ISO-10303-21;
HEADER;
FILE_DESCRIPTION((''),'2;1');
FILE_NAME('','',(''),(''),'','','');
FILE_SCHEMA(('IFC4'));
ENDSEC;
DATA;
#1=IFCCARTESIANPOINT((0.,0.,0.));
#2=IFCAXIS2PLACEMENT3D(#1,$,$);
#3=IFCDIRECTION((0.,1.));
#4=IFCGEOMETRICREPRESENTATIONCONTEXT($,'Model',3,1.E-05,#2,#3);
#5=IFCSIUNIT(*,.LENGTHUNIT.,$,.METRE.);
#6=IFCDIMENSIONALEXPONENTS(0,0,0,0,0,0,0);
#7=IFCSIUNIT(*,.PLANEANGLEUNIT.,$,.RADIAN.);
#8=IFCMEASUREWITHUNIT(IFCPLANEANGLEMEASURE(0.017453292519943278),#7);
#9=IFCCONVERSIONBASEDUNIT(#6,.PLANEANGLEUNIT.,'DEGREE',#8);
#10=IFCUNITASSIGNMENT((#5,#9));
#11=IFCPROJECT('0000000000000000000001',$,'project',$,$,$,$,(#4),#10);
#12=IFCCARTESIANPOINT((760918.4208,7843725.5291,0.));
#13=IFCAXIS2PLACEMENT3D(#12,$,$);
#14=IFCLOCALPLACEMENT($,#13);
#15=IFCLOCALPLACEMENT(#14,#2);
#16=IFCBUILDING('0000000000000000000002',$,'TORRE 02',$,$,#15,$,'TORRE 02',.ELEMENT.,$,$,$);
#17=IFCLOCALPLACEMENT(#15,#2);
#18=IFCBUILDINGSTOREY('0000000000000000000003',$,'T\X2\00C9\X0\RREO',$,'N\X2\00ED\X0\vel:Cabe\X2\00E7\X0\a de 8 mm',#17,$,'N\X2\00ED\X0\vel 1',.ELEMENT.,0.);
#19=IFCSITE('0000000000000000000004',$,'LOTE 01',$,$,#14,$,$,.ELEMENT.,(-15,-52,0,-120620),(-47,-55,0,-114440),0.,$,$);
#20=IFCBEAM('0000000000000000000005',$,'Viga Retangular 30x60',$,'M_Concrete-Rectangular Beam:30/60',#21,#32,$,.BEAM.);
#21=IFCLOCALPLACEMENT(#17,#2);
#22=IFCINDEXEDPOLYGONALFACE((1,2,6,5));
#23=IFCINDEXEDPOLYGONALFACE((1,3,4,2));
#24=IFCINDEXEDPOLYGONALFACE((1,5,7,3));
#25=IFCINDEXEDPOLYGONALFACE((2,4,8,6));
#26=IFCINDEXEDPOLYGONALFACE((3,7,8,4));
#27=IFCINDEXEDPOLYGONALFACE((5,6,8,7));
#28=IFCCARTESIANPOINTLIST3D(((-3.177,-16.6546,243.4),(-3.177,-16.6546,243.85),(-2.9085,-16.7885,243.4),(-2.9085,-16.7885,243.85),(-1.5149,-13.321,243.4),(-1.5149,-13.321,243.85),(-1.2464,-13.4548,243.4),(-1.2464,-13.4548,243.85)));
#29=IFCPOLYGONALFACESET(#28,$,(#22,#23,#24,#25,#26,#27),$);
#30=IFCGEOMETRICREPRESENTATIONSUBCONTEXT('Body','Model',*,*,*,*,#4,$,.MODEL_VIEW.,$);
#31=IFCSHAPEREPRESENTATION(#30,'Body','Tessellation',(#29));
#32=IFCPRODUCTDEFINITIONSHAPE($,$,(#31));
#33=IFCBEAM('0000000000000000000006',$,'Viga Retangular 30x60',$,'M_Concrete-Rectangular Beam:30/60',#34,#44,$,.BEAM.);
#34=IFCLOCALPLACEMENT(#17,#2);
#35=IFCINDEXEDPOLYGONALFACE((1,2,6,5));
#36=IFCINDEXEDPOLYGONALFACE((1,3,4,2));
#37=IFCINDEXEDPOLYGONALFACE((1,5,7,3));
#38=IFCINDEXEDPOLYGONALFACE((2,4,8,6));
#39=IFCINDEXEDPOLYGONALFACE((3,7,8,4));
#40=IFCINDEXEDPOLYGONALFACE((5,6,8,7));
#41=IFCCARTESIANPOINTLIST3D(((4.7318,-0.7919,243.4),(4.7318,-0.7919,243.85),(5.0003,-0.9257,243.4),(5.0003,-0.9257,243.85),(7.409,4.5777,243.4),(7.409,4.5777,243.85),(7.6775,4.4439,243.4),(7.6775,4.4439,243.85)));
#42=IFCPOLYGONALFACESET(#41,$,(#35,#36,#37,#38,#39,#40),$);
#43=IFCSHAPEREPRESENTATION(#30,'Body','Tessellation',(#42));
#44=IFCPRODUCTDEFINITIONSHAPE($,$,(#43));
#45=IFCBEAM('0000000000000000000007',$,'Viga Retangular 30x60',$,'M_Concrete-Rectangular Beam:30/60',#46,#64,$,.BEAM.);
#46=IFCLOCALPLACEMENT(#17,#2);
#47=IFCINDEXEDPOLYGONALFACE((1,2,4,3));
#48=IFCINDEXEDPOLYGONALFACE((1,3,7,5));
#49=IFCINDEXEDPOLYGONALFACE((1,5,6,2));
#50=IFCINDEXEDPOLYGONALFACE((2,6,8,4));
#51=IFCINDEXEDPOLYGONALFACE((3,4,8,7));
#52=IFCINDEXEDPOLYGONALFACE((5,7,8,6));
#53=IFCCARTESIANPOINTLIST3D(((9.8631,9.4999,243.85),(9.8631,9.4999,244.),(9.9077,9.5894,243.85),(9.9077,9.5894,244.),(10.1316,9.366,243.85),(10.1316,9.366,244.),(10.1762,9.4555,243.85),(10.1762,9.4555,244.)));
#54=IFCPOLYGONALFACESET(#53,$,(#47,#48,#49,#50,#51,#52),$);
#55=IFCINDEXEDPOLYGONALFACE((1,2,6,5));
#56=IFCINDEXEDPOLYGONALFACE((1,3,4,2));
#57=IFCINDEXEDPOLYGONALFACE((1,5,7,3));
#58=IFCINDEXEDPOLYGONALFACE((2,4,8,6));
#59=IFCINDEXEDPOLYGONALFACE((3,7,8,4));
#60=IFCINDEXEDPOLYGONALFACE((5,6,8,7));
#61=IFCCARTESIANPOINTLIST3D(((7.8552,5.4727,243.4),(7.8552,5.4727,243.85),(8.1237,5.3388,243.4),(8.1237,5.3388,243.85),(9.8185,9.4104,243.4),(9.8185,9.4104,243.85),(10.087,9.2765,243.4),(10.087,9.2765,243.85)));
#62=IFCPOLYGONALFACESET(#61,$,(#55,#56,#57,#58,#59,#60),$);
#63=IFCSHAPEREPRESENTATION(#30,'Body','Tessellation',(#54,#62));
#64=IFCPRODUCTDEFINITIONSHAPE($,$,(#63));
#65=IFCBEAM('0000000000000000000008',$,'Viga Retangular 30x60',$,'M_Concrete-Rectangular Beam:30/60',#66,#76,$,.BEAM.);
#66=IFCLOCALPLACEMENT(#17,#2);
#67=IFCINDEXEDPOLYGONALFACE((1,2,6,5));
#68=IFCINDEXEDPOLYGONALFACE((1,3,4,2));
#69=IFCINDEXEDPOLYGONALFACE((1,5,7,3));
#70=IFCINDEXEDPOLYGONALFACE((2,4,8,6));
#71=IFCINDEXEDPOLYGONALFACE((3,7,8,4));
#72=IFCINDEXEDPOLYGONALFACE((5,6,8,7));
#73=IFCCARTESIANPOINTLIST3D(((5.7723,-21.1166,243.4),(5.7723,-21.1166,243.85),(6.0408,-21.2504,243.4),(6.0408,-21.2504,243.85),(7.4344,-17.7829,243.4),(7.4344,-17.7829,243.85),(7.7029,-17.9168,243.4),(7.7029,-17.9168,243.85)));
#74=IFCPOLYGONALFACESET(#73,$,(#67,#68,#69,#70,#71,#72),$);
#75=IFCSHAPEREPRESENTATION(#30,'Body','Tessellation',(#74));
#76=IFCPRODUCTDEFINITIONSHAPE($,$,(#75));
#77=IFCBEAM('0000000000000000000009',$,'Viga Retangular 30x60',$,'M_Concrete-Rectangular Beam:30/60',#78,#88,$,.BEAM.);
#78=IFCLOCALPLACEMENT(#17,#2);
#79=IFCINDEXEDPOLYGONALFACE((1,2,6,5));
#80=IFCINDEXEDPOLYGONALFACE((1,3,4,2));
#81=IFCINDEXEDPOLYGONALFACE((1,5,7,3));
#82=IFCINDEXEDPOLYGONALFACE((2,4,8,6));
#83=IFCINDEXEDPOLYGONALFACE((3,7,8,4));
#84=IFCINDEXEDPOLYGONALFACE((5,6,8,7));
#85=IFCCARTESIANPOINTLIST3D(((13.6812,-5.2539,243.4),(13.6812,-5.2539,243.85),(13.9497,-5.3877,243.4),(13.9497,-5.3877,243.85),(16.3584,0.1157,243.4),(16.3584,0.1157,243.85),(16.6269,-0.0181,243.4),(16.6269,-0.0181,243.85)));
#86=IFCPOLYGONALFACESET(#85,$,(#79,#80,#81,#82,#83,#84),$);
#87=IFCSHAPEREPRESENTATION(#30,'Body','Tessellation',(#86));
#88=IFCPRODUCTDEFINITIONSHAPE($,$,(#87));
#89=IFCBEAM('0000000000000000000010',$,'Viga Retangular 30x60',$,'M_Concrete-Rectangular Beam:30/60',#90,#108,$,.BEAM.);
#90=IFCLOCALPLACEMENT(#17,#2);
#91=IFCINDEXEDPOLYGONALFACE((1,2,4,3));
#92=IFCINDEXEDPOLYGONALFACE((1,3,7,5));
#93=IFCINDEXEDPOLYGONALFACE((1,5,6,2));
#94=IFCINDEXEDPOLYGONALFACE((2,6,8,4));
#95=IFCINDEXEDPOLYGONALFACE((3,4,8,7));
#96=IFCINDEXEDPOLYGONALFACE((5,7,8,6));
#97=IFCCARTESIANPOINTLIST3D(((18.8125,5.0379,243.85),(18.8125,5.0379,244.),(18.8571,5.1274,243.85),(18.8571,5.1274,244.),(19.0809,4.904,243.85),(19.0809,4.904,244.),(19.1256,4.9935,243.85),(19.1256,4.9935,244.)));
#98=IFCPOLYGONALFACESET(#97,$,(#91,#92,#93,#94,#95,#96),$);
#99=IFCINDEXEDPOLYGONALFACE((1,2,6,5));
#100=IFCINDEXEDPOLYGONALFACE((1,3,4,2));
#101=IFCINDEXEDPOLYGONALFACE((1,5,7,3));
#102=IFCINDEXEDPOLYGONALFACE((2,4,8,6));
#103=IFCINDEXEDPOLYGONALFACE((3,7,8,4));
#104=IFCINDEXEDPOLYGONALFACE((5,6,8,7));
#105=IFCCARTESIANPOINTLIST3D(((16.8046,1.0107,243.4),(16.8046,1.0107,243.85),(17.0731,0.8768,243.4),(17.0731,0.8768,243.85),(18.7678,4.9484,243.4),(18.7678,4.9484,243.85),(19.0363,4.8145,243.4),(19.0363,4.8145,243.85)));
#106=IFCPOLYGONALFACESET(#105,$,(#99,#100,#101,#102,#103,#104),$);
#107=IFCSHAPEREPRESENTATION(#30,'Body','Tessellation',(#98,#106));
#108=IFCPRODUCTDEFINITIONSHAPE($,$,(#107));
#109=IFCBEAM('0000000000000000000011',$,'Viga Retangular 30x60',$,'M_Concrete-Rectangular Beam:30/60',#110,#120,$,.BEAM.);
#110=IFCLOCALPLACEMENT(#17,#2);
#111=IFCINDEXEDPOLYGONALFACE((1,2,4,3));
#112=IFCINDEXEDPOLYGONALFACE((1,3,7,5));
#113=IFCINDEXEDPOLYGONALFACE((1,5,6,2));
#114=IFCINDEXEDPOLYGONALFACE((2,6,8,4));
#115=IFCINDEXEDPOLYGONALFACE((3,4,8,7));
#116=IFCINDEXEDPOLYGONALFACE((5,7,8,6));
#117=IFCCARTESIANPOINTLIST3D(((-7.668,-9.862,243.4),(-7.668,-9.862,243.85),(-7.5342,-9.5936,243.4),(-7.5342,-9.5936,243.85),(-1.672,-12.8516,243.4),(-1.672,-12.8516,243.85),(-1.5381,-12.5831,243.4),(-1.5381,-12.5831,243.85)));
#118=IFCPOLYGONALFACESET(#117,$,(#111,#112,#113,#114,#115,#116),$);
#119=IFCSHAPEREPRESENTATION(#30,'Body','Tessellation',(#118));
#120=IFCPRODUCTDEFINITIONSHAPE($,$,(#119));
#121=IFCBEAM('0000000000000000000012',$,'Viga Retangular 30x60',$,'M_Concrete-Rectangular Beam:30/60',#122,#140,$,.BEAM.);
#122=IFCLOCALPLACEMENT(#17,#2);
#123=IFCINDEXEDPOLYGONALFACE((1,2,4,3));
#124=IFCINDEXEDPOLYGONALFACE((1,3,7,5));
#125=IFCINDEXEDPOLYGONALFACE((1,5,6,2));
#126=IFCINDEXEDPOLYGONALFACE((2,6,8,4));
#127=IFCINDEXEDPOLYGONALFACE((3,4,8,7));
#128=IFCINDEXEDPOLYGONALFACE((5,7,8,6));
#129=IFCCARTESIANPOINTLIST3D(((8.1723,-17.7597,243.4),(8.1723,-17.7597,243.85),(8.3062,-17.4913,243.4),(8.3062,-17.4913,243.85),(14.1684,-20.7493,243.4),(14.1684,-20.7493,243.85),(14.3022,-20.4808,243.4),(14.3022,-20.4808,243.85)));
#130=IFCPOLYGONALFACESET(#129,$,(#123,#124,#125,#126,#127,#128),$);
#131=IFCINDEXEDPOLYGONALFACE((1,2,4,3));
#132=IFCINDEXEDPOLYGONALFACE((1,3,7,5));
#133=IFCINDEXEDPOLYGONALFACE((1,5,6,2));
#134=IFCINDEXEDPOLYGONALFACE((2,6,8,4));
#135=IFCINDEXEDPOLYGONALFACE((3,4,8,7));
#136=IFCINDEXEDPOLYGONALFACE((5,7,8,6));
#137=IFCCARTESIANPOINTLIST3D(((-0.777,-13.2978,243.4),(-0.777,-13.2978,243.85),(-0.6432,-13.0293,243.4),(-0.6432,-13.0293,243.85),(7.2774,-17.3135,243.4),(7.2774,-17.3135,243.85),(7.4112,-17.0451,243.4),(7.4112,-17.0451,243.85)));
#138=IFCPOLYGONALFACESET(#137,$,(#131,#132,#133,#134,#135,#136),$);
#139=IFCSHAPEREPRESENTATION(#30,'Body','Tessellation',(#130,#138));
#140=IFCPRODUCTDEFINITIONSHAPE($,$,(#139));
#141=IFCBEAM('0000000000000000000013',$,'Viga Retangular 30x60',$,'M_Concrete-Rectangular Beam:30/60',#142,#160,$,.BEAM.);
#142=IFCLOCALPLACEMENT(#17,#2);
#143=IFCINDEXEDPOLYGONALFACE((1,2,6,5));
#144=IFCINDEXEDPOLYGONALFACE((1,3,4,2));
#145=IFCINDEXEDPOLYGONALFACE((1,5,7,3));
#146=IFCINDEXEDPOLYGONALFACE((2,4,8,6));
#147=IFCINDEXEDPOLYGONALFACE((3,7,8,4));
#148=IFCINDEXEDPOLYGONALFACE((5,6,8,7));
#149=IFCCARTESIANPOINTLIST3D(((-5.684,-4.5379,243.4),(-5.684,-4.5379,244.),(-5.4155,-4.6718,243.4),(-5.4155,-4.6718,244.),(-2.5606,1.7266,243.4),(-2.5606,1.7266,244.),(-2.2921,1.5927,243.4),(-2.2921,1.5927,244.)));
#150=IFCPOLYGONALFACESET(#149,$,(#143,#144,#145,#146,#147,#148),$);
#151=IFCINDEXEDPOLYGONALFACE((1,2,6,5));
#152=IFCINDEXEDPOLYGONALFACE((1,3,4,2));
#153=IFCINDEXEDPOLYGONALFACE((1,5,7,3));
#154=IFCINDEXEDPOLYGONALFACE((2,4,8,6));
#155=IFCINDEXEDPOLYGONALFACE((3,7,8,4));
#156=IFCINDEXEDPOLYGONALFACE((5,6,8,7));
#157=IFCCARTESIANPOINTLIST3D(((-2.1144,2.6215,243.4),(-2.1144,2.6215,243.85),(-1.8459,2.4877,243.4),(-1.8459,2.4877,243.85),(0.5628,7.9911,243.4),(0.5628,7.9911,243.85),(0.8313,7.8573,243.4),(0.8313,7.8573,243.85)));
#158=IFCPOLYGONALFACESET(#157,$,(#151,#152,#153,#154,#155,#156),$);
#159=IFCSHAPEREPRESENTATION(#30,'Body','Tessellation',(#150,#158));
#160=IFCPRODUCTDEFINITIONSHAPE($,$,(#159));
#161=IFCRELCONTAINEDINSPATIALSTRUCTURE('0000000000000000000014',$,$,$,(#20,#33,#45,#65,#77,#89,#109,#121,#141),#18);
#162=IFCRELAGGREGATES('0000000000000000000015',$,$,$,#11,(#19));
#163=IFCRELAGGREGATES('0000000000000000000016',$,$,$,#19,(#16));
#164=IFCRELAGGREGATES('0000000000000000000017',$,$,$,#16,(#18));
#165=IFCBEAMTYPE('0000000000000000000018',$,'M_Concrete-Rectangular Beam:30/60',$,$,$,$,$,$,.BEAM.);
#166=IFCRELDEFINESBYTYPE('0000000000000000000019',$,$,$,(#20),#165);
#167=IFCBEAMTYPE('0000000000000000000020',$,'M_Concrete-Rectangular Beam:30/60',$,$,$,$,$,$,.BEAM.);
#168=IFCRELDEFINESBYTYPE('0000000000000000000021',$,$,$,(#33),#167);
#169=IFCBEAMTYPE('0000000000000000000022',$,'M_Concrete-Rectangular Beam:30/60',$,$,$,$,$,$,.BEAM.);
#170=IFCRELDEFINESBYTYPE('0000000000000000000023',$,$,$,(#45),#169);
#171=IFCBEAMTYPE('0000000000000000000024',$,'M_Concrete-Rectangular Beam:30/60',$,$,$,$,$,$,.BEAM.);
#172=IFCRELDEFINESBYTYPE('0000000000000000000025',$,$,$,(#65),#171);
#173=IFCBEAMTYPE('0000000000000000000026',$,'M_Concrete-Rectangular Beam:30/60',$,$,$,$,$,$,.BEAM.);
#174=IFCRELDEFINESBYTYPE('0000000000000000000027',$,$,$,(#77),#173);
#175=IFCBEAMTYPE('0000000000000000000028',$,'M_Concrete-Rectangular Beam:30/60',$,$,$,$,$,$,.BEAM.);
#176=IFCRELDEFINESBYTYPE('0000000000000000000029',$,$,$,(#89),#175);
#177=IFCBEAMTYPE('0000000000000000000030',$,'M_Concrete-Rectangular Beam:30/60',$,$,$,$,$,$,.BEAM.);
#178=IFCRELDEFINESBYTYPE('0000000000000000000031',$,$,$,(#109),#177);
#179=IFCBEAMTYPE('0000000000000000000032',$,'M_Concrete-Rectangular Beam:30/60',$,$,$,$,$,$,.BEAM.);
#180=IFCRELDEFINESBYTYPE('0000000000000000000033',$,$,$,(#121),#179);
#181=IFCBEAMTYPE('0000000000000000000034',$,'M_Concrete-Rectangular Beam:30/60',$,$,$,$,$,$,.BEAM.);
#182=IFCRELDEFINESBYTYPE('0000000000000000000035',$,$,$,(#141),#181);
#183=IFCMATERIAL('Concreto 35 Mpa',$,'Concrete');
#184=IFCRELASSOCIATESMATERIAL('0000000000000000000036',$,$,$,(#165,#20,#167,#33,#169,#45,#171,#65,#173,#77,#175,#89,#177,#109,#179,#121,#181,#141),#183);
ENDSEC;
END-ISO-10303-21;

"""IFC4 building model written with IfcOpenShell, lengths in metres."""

from ifc_helpers import new_model, entity, si_unit, converted_unit, direction, frame, origin, place, context, subcontext, project, spatial, indexed_curve, outline, extrude, source, transform, mapped, material, type_object, type_shapes, element, save


model = new_model("IFC4")

# Units and contexts
model_context = context("Model", 3, precision=1e-05, world=origin(), true_north=direction((0.0, 1.0)))
body_context = subcontext(model_context, "Body", "Model", "MODEL_VIEW")
ifc_project = project(units=[si_unit("LENGTHUNIT", "METRE"), converted_unit("PLANEANGLEUNIT", "DEGREE", entity("IfcPlaneAngleMeasure", 0.017453292519943278), si_unit("PLANEANGLEUNIT", "RADIAN"), dimensions=[0, 0, 0, 0, 0, 0, 0])], contexts=[model_context])

# Site, building, storey
site_placement = place(None, frame((760918.4208, 7843725.5291, 0.0)))
site = spatial("IfcSite", under=ifc_project, at=site_placement, Name="LOTE 01", CompositionType="ELEMENT", RefLatitude=(-15, -52, 0, -120620), RefLongitude=(-47, -55, 0, -114440), RefElevation=0.0)
building_placement = place(site_placement, origin())
building = spatial("IfcBuilding", under=site, at=building_placement, Name="TORRE 02", LongName="TORRE 02", CompositionType="ELEMENT")
storey_placement = place(building_placement, origin())
storey = spatial("IfcBuildingStorey", under=building, at=storey_placement, Name="TÉRREO", ObjectType="Nível:Cabeça de 8 mm", LongName="Nível 1", CompositionType="ELEMENT", Elevation=0.0)

# Shared definitions
placement = place(building_placement, frame((0.0, 0.0, 244.0)))

# Beams
ifc_material_1 = material(Name="Concreto 35 Mpa", Category="Concrete")
beam_type_1 = type_object("IfcBeamType", Name="M_Concrete-Rectangular Beam:30/60", PredefinedType="BEAM", material=ifc_material_1)
shared_shape_1 = source(origin(), body_context, "Body", "SweptSolid", [
    extrude(outline(indexed_curve([(-0.225, -0.15), (0.225, -0.15), (0.225, 0.15), (-0.225, 0.15), (-0.225, -0.15)], self_intersect=False)), frame((-3.0428, -16.7215, 243.625), z_axis=(0.446198, 0.894934, 0.0), x_axis=(0.0, 0.0, 1.0)), (0.0, 0.0, 1.0), 3.725),
])
type_shapes(beam_type_1, [shared_shape_1])
beam_1_placement = place(placement, frame((0.0, 0.0, -244.0)))
element("IfcBeam", 1, at=beam_1_placement, inside=storey, type_object=beam_type_1, material=ifc_material_1, Name="Viga Retangular 30x60", ObjectType="M_Concrete-Rectangular Beam:30/60", PredefinedType="BEAM", context=body_context, shape_type="MappedRepresentation", body=[
    mapped(shared_shape_1, transform((0.0, 0.0, 0.0), scale=1.0)),
])
beam_type_2 = type_object("IfcBeamType", Name="M_Concrete-Rectangular Beam:30/60", PredefinedType="BEAM", material=ifc_material_1)
shared_shape_2 = source(origin(), body_context, "Body", "SweptSolid", [
    extrude(outline(indexed_curve([(-0.225, -0.15), (0.225, -0.15), (0.225, 0.15), (-0.225, 0.15), (-0.225, -0.15)], self_intersect=False)), frame((4.8661, -0.8588, 243.625), z_axis=(0.446198, 0.894934, 0.0), x_axis=(0.0, 0.0, 1.0)), (0.0, 0.0, 1.0), 6.0),
])
type_shapes(beam_type_2, [shared_shape_2])
beam_2_placement = place(placement, frame((0.0, 0.0, -244.0)))
element("IfcBeam", 2, at=beam_2_placement, inside=storey, type_object=beam_type_2, material=ifc_material_1, Name="Viga Retangular 30x60", ObjectType="M_Concrete-Rectangular Beam:30/60", PredefinedType="BEAM", context=body_context, shape_type="MappedRepresentation", body=[
    mapped(shared_shape_2, transform((0.0, 0.0, 0.0), scale=1.0)),
])
beam_type_3 = type_object("IfcBeamType", Name="M_Concrete-Rectangular Beam:30/60", PredefinedType="BEAM", material=ifc_material_1)
shared_shape_3 = source(origin(), body_context, "Body", "SweptSolid", [
    extrude(outline(indexed_curve([(-0.075, -0.15), (0.075, -0.15), (0.075, 0.15), (-0.075, 0.15), (-0.075, -0.15)], self_intersect=False)), frame((9.9974, 9.4329, 243.925), z_axis=(0.446198, 0.894934, 0.0), x_axis=(0.0, 0.0, 1.0)), (0.0, 0.0, 1.0), 0.1),
    extrude(outline(indexed_curve([(-0.225, -0.15), (0.225, -0.15), (0.225, 0.15), (-0.225, 0.15), (-0.225, -0.15)], self_intersect=False)), frame((7.9895, 5.4057, 243.625), z_axis=(0.446198, 0.894934, 0.0), x_axis=(0.0, 0.0, 1.0)), (0.0, 0.0, 1.0), 4.4),
])
type_shapes(beam_type_3, [shared_shape_3])
beam_3_placement = place(placement, frame((0.0, 0.0, -244.0)))
element("IfcBeam", 3, at=beam_3_placement, inside=storey, type_object=beam_type_3, material=ifc_material_1, Name="Viga Retangular 30x60", ObjectType="M_Concrete-Rectangular Beam:30/60", PredefinedType="BEAM", context=body_context, shape_type="MappedRepresentation", body=[
    mapped(shared_shape_3, transform((0.0, 0.0, 0.0), scale=1.0)),
])
beam_type_4 = type_object("IfcBeamType", Name="M_Concrete-Rectangular Beam:30/60", PredefinedType="BEAM", material=ifc_material_1)
shared_shape_4 = source(origin(), body_context, "Body", "SweptSolid", [
    extrude(outline(indexed_curve([(-0.225, -0.15), (0.225, -0.15), (0.225, 0.15), (-0.225, 0.15), (-0.225, -0.15)], self_intersect=False)), frame((5.9066, -21.1835, 243.625), z_axis=(0.446198, 0.894934, 0.0), x_axis=(0.0, 0.0, 1.0)), (0.0, 0.0, 1.0), 3.725),
])
type_shapes(beam_type_4, [shared_shape_4])
beam_4_placement = place(placement, frame((0.0, 0.0, -244.0)))
element("IfcBeam", 4, at=beam_4_placement, inside=storey, type_object=beam_type_4, material=ifc_material_1, Name="Viga Retangular 30x60", ObjectType="M_Concrete-Rectangular Beam:30/60", PredefinedType="BEAM", context=body_context, shape_type="MappedRepresentation", body=[
    mapped(shared_shape_4, transform((0.0, 0.0, 0.0), scale=1.0)),
])
beam_type_5 = type_object("IfcBeamType", Name="M_Concrete-Rectangular Beam:30/60", PredefinedType="BEAM", material=ifc_material_1)
shared_shape_5 = source(origin(), body_context, "Body", "SweptSolid", [
    extrude(outline(indexed_curve([(-0.225, -0.15), (0.225, -0.15), (0.225, 0.15), (-0.225, 0.15), (-0.225, -0.15)], self_intersect=False)), frame((13.8154, -5.3208, 243.625), z_axis=(0.446198, 0.894934, 0.0), x_axis=(0.0, 0.0, 1.0)), (0.0, 0.0, 1.0), 6.0),
])
type_shapes(beam_type_5, [shared_shape_5])
beam_5_placement = place(placement, frame((0.0, 0.0, -244.0)))
element("IfcBeam", 5, at=beam_5_placement, inside=storey, type_object=beam_type_5, material=ifc_material_1, Name="Viga Retangular 30x60", ObjectType="M_Concrete-Rectangular Beam:30/60", PredefinedType="BEAM", context=body_context, shape_type="MappedRepresentation", body=[
    mapped(shared_shape_5, transform((0.0, 0.0, 0.0), scale=1.0)),
])
beam_type_6 = type_object("IfcBeamType", Name="M_Concrete-Rectangular Beam:30/60", PredefinedType="BEAM", material=ifc_material_1)
shared_shape_6 = source(origin(), body_context, "Body", "SweptSolid", [
    extrude(outline(indexed_curve([(-0.075, -0.15), (0.075, -0.15), (0.075, 0.15), (-0.075, 0.15), (-0.075, -0.15)], self_intersect=False)), frame((18.9467, 4.971, 243.925), z_axis=(0.446198, 0.894934, 0.0), x_axis=(0.0, 0.0, 1.0)), (0.0, 0.0, 1.0), 0.1),
    extrude(outline(indexed_curve([(-0.225, -0.15), (0.225, -0.15), (0.225, 0.15), (-0.225, 0.15), (-0.225, -0.15)], self_intersect=False)), frame((16.9388, 0.9438, 243.625), z_axis=(0.446198, 0.894934, 0.0), x_axis=(0.0, 0.0, 1.0)), (0.0, 0.0, 1.0), 4.4),
])
type_shapes(beam_type_6, [shared_shape_6])
beam_6_placement = place(placement, frame((0.0, 0.0, -244.0)))
element("IfcBeam", 6, at=beam_6_placement, inside=storey, type_object=beam_type_6, material=ifc_material_1, Name="Viga Retangular 30x60", ObjectType="M_Concrete-Rectangular Beam:30/60", PredefinedType="BEAM", context=body_context, shape_type="MappedRepresentation", body=[
    mapped(shared_shape_6, transform((0.0, 0.0, 0.0), scale=1.0)),
])
beam_type_7 = type_object("IfcBeamType", Name="M_Concrete-Rectangular Beam:30/60", PredefinedType="BEAM", material=ifc_material_1)
shared_shape_7 = source(origin(), body_context, "Body", "SweptSolid", [
    extrude(outline(indexed_curve([(-0.225, -0.15), (0.225, -0.15), (0.225, 0.15), (-0.225, 0.15), (-0.225, -0.15)], self_intersect=False)), frame((-7.6011, -9.7278, 243.625), z_axis=(0.894934, -0.446198, 0.0), x_axis=(0.0, 0.0, -1.0)), (0.0, 0.0, 1.0), 6.7),
])
type_shapes(beam_type_7, [shared_shape_7])
beam_7_placement = place(placement, frame((0.0, 0.0, -244.0)))
element("IfcBeam", 7, at=beam_7_placement, inside=storey, type_object=beam_type_7, material=ifc_material_1, Name="Viga Retangular 30x60", ObjectType="M_Concrete-Rectangular Beam:30/60", PredefinedType="BEAM", context=body_context, shape_type="MappedRepresentation", body=[
    mapped(shared_shape_7, transform((0.0, 0.0, 0.0), scale=1.0)),
])
beam_type_8 = type_object("IfcBeamType", Name="M_Concrete-Rectangular Beam:30/60", PredefinedType="BEAM", material=ifc_material_1)
shared_shape_8 = source(origin(), body_context, "Body", "SweptSolid", [
    extrude(outline(indexed_curve([(-0.225, -0.15), (0.225, -0.15), (0.225, 0.15), (-0.225, 0.15), (-0.225, -0.15)], self_intersect=False)), frame((8.2392, -17.6255, 243.625), z_axis=(0.894934, -0.446198, 0.0), x_axis=(0.0, 0.0, -1.0)), (0.0, 0.0, 1.0), 6.7),
    extrude(outline(indexed_curve([(-0.225, -0.15), (0.225, -0.15), (0.225, 0.15), (-0.225, 0.15), (-0.225, -0.15)], self_intersect=False)), frame((-0.7101, -13.1635, 243.625), z_axis=(0.894934, -0.446198, 0.0), x_axis=(0.0, 0.0, -1.0)), (0.0, 0.0, 1.0), 9.0),
])
type_shapes(beam_type_8, [shared_shape_8])
beam_8_placement = place(placement, frame((0.0, 0.0, -244.0)))
element("IfcBeam", 8, at=beam_8_placement, inside=storey, type_object=beam_type_8, material=ifc_material_1, Name="Viga Retangular 30x60", ObjectType="M_Concrete-Rectangular Beam:30/60", PredefinedType="BEAM", context=body_context, shape_type="MappedRepresentation", body=[
    mapped(shared_shape_8, transform((0.0, 0.0, 0.0), scale=1.0)),
])
beam_type_9 = type_object("IfcBeamType", Name="M_Concrete-Rectangular Beam:30/60", PredefinedType="BEAM", material=ifc_material_1)
shared_shape_9 = source(origin(), body_context, "Body", "SweptSolid", [
    extrude(outline(indexed_curve([(-0.3, -0.15), (0.3, -0.15), (0.3, 0.15), (-0.3, 0.15), (-0.3, -0.15)], self_intersect=False)), frame((-5.5497, -4.6049, 243.7), z_axis=(0.446198, 0.894934, 0.0), x_axis=(0.0, 0.0, 1.0)), (0.0, 0.0, 1.0), 7.0),
    extrude(outline(indexed_curve([(-0.225, -0.15), (0.225, -0.15), (0.225, 0.15), (-0.225, 0.15), (-0.225, -0.15)], self_intersect=False)), frame((-1.9802, 2.5546, 243.625), z_axis=(0.446198, 0.894934, 0.0), x_axis=(0.0, 0.0, 1.0)), (0.0, 0.0, 1.0), 6.0),
])
type_shapes(beam_type_9, [shared_shape_9])
beam_9_placement = place(placement, frame((0.0, 0.0, -244.0)))
element("IfcBeam", 9, at=beam_9_placement, inside=storey, type_object=beam_type_9, material=ifc_material_1, Name="Viga Retangular 30x60", ObjectType="M_Concrete-Rectangular Beam:30/60", PredefinedType="BEAM", context=body_context, shape_type="MappedRepresentation", body=[
    mapped(shared_shape_9, transform((0.0, 0.0, 0.0), scale=1.0)),
])

save(model, "model.ifc")
